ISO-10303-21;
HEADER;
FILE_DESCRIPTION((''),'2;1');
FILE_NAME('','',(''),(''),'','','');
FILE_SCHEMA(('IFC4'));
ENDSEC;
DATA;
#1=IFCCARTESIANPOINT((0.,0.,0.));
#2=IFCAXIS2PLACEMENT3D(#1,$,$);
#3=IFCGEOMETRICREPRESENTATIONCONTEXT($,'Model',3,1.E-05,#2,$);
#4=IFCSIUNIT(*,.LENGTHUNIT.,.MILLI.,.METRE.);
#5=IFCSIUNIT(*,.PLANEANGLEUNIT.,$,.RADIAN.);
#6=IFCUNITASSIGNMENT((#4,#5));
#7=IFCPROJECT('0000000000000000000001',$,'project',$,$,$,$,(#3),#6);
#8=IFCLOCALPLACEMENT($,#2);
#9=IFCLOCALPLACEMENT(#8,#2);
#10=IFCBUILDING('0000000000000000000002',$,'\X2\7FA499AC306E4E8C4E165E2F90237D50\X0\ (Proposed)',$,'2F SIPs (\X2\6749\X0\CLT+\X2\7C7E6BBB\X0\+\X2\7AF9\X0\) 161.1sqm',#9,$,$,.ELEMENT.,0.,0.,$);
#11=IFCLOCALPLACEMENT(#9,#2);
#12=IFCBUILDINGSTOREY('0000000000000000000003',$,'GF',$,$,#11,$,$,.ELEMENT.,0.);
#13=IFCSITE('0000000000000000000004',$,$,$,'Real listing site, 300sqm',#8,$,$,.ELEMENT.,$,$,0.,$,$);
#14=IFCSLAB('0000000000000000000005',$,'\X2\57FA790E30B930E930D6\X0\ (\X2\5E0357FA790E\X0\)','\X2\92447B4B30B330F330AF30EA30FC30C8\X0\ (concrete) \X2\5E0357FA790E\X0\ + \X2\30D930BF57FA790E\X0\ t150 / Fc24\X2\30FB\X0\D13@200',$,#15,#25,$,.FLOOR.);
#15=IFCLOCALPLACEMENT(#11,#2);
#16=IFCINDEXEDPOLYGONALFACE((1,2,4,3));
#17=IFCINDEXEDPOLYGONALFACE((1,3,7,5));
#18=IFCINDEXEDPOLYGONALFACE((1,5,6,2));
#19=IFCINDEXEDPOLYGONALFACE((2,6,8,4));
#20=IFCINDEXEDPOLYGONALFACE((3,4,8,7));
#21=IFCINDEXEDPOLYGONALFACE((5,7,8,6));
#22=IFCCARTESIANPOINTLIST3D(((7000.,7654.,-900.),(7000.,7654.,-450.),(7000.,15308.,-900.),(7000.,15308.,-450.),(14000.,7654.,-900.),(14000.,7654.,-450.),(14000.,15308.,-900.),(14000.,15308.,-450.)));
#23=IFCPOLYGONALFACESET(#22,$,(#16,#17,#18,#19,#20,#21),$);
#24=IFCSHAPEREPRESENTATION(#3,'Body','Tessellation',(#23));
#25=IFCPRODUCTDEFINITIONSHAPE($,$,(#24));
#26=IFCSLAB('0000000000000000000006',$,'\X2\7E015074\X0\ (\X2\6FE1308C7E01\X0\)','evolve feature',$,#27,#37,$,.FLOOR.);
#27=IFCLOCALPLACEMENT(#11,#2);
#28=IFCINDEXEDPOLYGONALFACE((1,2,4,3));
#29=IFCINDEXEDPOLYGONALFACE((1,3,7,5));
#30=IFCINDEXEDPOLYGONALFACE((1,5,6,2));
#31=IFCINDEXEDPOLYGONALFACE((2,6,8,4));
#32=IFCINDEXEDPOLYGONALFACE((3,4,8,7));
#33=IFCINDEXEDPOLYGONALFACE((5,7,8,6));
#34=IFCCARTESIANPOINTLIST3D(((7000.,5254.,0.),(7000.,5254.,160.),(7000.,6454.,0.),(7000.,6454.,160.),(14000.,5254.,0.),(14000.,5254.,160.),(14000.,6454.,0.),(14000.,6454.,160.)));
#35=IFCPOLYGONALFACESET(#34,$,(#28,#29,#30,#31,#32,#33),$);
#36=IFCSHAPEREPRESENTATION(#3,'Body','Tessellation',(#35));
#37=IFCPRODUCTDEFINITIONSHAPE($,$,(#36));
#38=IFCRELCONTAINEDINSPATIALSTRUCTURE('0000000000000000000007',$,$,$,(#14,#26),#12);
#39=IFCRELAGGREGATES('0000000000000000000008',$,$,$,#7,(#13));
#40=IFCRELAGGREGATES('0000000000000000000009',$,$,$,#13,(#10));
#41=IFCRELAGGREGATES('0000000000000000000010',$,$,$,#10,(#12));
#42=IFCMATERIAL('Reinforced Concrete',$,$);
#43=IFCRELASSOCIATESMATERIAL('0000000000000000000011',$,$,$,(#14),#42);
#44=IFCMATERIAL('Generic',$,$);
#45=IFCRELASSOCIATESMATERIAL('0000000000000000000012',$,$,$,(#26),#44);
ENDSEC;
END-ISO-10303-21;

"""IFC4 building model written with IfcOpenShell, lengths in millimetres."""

from ifc_helpers import new_model, si_unit, frame, frame_2d, origin, place, context, project, spatial, rectangle, extrude, material, element, save


model = new_model("IFC4")

# Units and contexts
model_context = context("Model", 3, precision=1e-05, world=origin())
ifc_project = project(units=[si_unit("LENGTHUNIT", "METRE", prefix="MILLI"), si_unit("PLANEANGLEUNIT", "RADIAN")], contexts=[model_context])

# Site, building, storey
site_placement = place(None, origin())
site = spatial("IfcSite", under=ifc_project, at=site_placement, ObjectType="Real listing site, 300sqm", CompositionType="ELEMENT", RefElevation=0.0)
building_placement = place(site_placement, origin())
building = spatial("IfcBuilding", under=site, at=building_placement, Name="群馬の二世帯連結 (Proposed)", ObjectType="2F SIPs (杉CLT+籾殻+竹) 161.1sqm", CompositionType="ELEMENT", ElevationOfRefHeight=0.0, ElevationOfTerrain=0.0)
storey_placement = place(building_placement, origin())
storey = spatial("IfcBuildingStorey", under=building, at=storey_placement, Name="GF", CompositionType="ELEMENT", Elevation=0.0)

# Slabs
ifc_material_1 = material(Name="Reinforced Concrete")
slab_1_placement = place(storey_placement, frame((3500.0, 3827.0, -450.0)))
element("IfcSlab", 1, at=slab_1_placement, inside=storey, material=ifc_material_1, Name="基礎スラブ (布基礎)", Description="鉄筋コンクリート (concrete) 布基礎 + ベタ基礎 t150 / Fc24・D13@200", PredefinedType="FLOOR", context=model_context, shape_type="SweptSolid", body=[
    extrude(rectangle(XDim=7000.0, YDim=7654.0, at=frame_2d((3500.0, 3827.0))), frame((3500.0, 3827.0, -450.0)), (0.0, 0.0, 1.0), 450.0),
])
ifc_material_2 = material(Name="Generic")
slab_2_placement = place(storey_placement, frame((3500.0, 2627.0, 0.0)))
element("IfcSlab", 2, at=slab_2_placement, inside=storey, material=ifc_material_2, Name="縁側 (濡れ縁)", Description="evolve feature", PredefinedType="FLOOR", context=model_context, shape_type="SweptSolid", body=[
    extrude(rectangle(XDim=7000.0, YDim=1200.0, at=frame_2d((3500.0, 600.0))), frame((3500.0, 2627.0, 0.0)), (0.0, 0.0, 1.0), 160.0),
])

save(model, "model.ifc")
